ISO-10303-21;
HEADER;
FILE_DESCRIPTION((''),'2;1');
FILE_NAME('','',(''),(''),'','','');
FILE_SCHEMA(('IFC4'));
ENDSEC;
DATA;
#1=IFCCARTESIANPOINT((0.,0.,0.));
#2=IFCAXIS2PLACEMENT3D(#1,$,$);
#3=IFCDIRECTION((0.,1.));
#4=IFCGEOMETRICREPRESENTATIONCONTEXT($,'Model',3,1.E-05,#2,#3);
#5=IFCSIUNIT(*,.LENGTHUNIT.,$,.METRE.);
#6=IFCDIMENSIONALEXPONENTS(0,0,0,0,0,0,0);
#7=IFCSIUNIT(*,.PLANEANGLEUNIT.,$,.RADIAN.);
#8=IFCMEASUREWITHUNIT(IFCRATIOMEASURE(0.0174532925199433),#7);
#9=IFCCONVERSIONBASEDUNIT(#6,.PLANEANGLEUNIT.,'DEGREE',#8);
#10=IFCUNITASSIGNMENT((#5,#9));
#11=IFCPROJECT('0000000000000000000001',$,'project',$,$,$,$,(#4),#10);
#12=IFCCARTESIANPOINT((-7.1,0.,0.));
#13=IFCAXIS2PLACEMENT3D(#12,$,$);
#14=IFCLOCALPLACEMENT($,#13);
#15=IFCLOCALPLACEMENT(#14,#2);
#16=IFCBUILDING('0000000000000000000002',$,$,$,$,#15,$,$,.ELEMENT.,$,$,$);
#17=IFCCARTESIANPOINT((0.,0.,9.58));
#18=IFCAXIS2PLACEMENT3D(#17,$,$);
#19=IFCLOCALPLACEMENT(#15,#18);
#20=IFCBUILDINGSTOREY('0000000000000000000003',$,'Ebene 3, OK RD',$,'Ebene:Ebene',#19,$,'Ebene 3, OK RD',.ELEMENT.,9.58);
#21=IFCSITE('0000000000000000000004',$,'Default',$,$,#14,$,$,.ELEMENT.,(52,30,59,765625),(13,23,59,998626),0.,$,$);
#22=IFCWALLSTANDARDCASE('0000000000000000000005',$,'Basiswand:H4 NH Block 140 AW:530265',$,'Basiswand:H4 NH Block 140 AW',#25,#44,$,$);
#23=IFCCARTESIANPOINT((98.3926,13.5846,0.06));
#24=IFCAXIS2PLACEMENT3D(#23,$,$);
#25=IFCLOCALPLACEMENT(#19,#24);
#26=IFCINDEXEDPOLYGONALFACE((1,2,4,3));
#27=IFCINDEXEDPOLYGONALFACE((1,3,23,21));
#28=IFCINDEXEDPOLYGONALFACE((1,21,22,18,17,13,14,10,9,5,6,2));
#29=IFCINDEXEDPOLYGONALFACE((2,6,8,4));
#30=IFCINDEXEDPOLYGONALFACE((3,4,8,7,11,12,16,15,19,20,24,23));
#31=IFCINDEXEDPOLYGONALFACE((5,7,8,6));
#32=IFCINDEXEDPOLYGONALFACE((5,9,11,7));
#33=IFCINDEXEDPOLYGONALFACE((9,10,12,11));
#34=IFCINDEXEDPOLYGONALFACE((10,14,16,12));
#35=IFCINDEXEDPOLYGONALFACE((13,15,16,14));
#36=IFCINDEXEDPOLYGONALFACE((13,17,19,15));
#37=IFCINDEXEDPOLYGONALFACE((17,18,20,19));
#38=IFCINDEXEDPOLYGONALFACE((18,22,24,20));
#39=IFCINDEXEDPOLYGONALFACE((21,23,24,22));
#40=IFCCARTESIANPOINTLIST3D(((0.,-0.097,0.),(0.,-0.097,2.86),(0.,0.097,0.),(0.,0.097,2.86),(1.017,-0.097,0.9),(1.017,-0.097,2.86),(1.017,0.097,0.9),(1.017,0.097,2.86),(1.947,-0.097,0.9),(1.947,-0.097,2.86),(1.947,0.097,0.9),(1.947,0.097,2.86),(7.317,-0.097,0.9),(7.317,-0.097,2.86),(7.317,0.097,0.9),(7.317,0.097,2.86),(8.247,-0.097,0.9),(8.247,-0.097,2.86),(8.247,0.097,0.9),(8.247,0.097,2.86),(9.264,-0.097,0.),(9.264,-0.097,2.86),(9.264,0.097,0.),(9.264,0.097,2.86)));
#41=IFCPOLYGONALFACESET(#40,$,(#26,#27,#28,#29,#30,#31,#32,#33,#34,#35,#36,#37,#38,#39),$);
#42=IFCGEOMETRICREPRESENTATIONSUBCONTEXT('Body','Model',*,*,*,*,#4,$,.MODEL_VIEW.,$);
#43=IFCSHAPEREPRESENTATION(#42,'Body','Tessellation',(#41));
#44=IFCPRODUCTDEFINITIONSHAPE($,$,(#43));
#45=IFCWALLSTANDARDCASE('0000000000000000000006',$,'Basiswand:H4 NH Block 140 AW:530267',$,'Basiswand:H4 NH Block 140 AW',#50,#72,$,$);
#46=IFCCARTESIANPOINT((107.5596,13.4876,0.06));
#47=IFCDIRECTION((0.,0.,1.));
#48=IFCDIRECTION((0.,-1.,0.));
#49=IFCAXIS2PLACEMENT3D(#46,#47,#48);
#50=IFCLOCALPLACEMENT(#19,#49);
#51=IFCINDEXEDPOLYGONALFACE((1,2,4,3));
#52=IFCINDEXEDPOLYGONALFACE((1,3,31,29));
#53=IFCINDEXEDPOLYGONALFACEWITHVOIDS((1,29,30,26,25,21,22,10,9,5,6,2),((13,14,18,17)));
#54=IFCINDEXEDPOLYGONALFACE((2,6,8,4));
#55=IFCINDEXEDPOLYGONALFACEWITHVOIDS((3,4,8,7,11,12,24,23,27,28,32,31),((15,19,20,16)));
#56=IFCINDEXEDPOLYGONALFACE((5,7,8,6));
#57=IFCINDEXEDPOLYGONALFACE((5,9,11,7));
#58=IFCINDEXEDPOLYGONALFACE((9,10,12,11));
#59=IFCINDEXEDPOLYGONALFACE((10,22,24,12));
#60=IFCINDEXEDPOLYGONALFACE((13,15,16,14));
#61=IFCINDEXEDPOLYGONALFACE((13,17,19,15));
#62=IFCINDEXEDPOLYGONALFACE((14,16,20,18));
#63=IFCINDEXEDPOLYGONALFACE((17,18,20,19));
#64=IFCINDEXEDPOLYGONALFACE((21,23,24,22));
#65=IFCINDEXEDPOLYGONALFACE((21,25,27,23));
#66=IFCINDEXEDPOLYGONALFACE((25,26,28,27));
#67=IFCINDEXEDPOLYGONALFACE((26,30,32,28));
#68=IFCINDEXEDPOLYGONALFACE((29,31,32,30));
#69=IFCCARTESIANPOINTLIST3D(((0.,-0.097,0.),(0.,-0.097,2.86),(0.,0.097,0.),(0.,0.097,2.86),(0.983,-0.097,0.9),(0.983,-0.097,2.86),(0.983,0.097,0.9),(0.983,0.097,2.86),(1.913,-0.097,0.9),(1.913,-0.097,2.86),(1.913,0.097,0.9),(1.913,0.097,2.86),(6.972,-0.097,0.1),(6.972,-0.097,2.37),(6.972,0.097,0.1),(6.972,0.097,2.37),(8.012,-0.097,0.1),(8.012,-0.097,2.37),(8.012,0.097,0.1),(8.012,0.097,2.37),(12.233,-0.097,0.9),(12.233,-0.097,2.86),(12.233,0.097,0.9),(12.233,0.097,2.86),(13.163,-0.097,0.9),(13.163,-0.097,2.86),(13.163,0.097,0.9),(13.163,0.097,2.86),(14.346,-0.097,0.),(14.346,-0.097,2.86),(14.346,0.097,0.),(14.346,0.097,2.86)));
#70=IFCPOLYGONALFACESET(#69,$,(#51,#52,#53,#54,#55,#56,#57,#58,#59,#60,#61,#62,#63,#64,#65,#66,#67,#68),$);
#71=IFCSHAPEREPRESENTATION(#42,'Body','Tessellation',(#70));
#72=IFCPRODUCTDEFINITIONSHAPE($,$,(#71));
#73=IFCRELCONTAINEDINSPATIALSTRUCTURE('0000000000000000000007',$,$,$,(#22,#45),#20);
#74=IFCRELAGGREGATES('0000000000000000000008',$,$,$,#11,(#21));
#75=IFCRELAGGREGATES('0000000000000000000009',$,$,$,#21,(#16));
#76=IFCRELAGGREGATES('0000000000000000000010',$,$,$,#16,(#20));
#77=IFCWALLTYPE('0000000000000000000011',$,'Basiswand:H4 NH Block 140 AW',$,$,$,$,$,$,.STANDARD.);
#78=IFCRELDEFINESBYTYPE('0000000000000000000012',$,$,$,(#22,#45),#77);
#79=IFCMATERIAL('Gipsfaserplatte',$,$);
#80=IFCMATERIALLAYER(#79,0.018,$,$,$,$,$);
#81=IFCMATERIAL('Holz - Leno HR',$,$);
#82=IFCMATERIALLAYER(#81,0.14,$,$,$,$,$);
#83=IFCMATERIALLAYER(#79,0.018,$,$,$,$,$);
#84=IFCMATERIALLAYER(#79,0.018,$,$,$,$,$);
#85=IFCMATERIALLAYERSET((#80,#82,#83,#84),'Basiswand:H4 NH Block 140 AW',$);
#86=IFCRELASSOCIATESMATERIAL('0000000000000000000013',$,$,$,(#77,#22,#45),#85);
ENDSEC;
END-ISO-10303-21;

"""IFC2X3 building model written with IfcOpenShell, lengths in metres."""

from ifc_helpers import new_model, entity, si_unit, converted_unit, direction, frame, frame_2d, origin, origin_2d_with_axis, place, context, subcontext, project, spatial, rectangle, extrude, material, layer, layer_set, layer_usage, type_object, element, save


model = new_model("IFC2X3")

# Units and contexts
model_context = context("Model", 3, precision=1e-05, world=origin(), true_north=direction((0.0, 1.0)))
body_context = subcontext(model_context, "Body", "Model", "MODEL_VIEW")
ifc_project = project(units=[si_unit("LENGTHUNIT", "METRE"), converted_unit("PLANEANGLEUNIT", "DEGREE", entity("IfcRatioMeasure", 0.0174532925199433), si_unit("PLANEANGLEUNIT", "RADIAN"), dimensions=[0, 0, 0, 0, 0, 0, 0])], contexts=[model_context])

# Site, building, storey
site_placement = place(None, frame((-7.1, 0.0, 0.0)))
site = spatial("IfcSite", under=ifc_project, at=site_placement, Name="Default", CompositionType="ELEMENT", RefLatitude=(52, 30, 59, 765625), RefLongitude=(13, 23, 59, 998626), RefElevation=0.0)
building_placement = place(site_placement, origin())
building = spatial("IfcBuilding", under=site, at=building_placement, CompositionType="ELEMENT")
storey_placement = place(building_placement, frame((0.0, 0.0, 9.58)))
storey = spatial("IfcBuildingStorey", under=building, at=storey_placement, Name="Ebene 3, OK RD", ObjectType="Ebene:Ebene", LongName="Ebene 3, OK RD", CompositionType="ELEMENT", Elevation=9.58)

# Walls, openings
ifc_material_1 = material(Name="Gipsfaserplatte")
ifc_layer_1 = layer(ifc_material_1, 0.018)
ifc_material_2 = material(Name="Holz - Leno HR")
ifc_layer_2 = layer(ifc_material_2, 0.14)
ifc_layer_3 = layer(ifc_material_1, 0.018)
ifc_layer_4 = layer(ifc_material_1, 0.018)
ifc_layer_set_1 = layer_set([ifc_layer_1, ifc_layer_2, ifc_layer_3, ifc_layer_4], Name="Basiswand:H4 NH Block 140 AW")
ifc_layer_usage_1 = layer_usage(ifc_layer_set_1, "AXIS2", "NEGATIVE", 0.097)
wall_type_1 = type_object("IfcWallType", Name="Basiswand:H4 NH Block 140 AW", PredefinedType="STANDARD", material=ifc_layer_set_1)
wall_1_placement = place(storey_placement, frame((98.3926, 13.5846, 0.06)))
wall_1 = element("IfcWallStandardCase", 1, at=wall_1_placement, inside=storey, type_object=wall_type_1, material=ifc_layer_usage_1, Name="Basiswand:H4 NH Block 140 AW:530265", ObjectType="Basiswand:H4 NH Block 140 AW", context=body_context, shape_type="SweptSolid", body=[
    extrude(rectangle(XDim=9.264, YDim=0.194, at=frame_2d((4.632, 0.0), x_axis=(-1.0, 0.0))), origin(), (0.0, 0.0, 1.0), 2.86),
])
opening_1_placement = place(wall_1_placement, origin())
element("IfcOpeningElement", 2, at=opening_1_placement, cuts=wall_1, ObjectType="Opening", context=body_context, shape_type="SweptSolid", body=[
    extrude(rectangle(XDim=2.0, YDim=0.93, at=origin_2d_with_axis()), frame((7.782, -0.097, 1.9), z_axis=(0.0, 1.0, 0.0), x_axis=(0.0, 0.0, -1.0)), (0.0, 0.0, 1.0), 0.194),
])
opening_2_placement = place(wall_1_placement, origin())
element("IfcOpeningElement", 3, at=opening_2_placement, cuts=wall_1, ObjectType="Opening", context=body_context, shape_type="SweptSolid", body=[
    extrude(rectangle(XDim=2.0, YDim=0.93, at=frame_2d((0.0, 0.0), x_axis=(1.0, 0.0))), frame((1.482, -0.097, 1.9), z_axis=(0.0, 1.0, 0.0), x_axis=(0.0, 0.0, -1.0)), (0.0, 0.0, 1.0), 0.194),
])
ifc_layer_usage_2 = layer_usage(ifc_layer_set_1, "AXIS2", "NEGATIVE", 0.097)
wall_2_placement = place(storey_placement, frame((107.5596, 13.4876, 0.06), z_axis=(0.0, 0.0, 1.0), x_axis=(0.0, -1.0, 0.0)))
wall_2 = element("IfcWallStandardCase", 4, at=wall_2_placement, inside=storey, type_object=wall_type_1, material=ifc_layer_usage_2, Name="Basiswand:H4 NH Block 140 AW:530267", ObjectType="Basiswand:H4 NH Block 140 AW", context=body_context, shape_type="SweptSolid", body=[
    extrude(rectangle(XDim=14.346, YDim=0.194, at=frame_2d((7.173, 0.0), x_axis=(-1.0, 0.0))), origin(), (0.0, 0.0, 1.0), 2.86),
])
opening_3_placement = place(wall_2_placement, origin())
element("IfcOpeningElement", 5, at=opening_3_placement, cuts=wall_2, ObjectType="Opening", context=body_context, shape_type="SweptSolid", body=[
    extrude(rectangle(XDim=2.0, YDim=0.93, at=origin_2d_with_axis()), frame((12.698, -0.097, 1.9), z_axis=(0.0, 1.0, 0.0), x_axis=(0.0, 0.0, -1.0)), (0.0, 0.0, 1.0), 0.194),
])
opening_4_placement = place(wall_2_placement, origin())
element("IfcOpeningElement", 6, at=opening_4_placement, cuts=wall_2, ObjectType="Opening", context=body_context, shape_type="SweptSolid", body=[
    extrude(rectangle(XDim=2.27, YDim=1.04, at=frame_2d((0.0, 0.0), x_axis=(1.0, 0.0))), frame((7.492, -0.097, 1.235), z_axis=(0.0, 1.0, 0.0), x_axis=(0.0, 0.0, -1.0)), (0.0, 0.0, 1.0), 0.194),
])
opening_5_placement = place(wall_2_placement, origin())
element("IfcOpeningElement", 7, at=opening_5_placement, cuts=wall_2, ObjectType="Opening", context=body_context, shape_type="SweptSolid", body=[
    extrude(rectangle(XDim=2.0, YDim=0.93, at=frame_2d((0.0, 0.0), x_axis=(1.0, 0.0))), frame((1.448, -0.097, 1.9), z_axis=(0.0, 1.0, 0.0), x_axis=(0.0, 0.0, -1.0)), (0.0, 0.0, 1.0), 0.194),
])

save(model, "model.ifc")
